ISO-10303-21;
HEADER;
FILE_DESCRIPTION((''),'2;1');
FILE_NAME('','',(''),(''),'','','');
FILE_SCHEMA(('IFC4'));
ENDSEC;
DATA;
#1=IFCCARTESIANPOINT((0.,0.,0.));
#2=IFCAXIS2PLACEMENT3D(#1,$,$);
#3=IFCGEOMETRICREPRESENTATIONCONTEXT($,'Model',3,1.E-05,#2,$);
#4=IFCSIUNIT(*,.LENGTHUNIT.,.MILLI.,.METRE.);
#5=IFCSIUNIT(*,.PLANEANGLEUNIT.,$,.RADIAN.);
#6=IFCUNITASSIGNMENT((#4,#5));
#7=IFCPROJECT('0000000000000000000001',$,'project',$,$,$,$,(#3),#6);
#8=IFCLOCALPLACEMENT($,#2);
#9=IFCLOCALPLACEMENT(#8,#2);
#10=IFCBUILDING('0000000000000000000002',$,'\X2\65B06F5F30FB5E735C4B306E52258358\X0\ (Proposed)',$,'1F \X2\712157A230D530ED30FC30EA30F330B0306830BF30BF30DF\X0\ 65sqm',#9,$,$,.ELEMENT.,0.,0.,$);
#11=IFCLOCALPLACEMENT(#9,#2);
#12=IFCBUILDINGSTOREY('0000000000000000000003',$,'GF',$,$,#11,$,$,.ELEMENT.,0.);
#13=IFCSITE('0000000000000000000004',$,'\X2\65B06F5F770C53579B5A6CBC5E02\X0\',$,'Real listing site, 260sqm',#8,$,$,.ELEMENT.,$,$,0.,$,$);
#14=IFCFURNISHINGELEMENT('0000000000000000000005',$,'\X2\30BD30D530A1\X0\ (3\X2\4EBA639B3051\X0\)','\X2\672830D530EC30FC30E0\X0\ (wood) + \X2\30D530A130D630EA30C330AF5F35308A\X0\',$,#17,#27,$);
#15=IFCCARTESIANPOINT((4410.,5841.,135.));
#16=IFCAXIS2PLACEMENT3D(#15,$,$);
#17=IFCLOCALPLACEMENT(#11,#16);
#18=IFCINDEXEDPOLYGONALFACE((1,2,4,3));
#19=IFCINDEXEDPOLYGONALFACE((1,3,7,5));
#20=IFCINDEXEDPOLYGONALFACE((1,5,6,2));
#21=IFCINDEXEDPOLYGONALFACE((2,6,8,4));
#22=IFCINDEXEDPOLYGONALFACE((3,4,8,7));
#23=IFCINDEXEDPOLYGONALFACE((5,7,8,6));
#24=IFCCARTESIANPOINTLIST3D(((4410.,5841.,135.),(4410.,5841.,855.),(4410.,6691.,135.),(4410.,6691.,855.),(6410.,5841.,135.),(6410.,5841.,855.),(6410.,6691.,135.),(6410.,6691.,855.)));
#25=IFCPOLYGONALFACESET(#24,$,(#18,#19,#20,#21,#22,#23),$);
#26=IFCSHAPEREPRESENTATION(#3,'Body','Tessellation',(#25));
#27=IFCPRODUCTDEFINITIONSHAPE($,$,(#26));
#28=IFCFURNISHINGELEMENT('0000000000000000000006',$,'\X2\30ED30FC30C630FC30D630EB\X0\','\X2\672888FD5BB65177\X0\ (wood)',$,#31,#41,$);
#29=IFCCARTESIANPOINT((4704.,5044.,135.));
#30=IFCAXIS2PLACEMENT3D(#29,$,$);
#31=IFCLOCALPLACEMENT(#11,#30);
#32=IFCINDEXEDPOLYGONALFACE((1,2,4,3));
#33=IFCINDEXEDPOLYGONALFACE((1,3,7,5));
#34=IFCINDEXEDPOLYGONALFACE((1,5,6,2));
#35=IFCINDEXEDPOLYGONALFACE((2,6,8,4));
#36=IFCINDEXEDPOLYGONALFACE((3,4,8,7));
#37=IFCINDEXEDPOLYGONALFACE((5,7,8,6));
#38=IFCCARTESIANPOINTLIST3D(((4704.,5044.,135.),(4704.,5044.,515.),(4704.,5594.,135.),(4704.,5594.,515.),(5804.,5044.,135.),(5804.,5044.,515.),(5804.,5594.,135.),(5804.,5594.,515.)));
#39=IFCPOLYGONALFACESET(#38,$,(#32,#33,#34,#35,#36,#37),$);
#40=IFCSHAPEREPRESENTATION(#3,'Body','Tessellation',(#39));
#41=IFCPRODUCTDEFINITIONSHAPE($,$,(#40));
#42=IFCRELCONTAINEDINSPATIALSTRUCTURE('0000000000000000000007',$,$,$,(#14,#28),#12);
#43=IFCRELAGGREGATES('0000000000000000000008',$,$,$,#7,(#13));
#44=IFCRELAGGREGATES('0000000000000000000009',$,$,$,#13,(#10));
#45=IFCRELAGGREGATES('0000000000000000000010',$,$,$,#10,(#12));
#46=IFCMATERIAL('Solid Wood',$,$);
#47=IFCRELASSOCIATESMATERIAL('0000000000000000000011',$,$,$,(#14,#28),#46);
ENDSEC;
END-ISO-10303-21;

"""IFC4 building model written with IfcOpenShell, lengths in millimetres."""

from ifc_helpers import new_model, si_unit, frame, frame_2d, origin, place, context, project, spatial, rectangle, extrude, material, element, save


model = new_model("IFC4")

# Units and contexts
model_context = context("Model", 3, precision=1e-05, world=origin())
ifc_project = project(units=[si_unit("LENGTHUNIT", "METRE", prefix="MILLI"), si_unit("PLANEANGLEUNIT", "RADIAN")], contexts=[model_context])

# Site, building, storey
site_placement = place(None, origin())
site = spatial("IfcSite", under=ifc_project, at=site_placement, Name="新潟県南魚沼市", ObjectType="Real listing site, 260sqm", CompositionType="ELEMENT", RefElevation=0.0)
building_placement = place(site_placement, origin())
building = spatial("IfcBuilding", under=site, at=building_placement, Name="新潟・平屋の別荘 (Proposed)", ObjectType="1F 無垢フローリングとタタミ 65sqm", CompositionType="ELEMENT", ElevationOfRefHeight=0.0, ElevationOfTerrain=0.0)
storey_placement = place(building_placement, origin())
storey = spatial("IfcBuildingStorey", under=building, at=storey_placement, Name="GF", CompositionType="ELEMENT", Elevation=0.0)

# Shared definitions
ifc_material_1 = material(Name="Solid Wood")

# Furnishing elements
furnishing_1_placement = place(storey_placement, frame((4410.0, 5841.0, 135.0)))
element("IfcFurnishingElement", 1, at=furnishing_1_placement, inside=storey, material=ifc_material_1, Name="ソファ (3人掛け)", Description="木フレーム (wood) + ファブリック張り", context=model_context, shape_type="SweptSolid", body=[
    extrude(rectangle(XDim=2000.0, YDim=850.0, at=frame_2d((1000.0, 425.0))), frame((4410.0, 5841.0, 135.0)), (0.0, 0.0, 1.0), 720.0),
])
furnishing_2_placement = place(storey_placement, frame((4704.0, 5044.0, 135.0)))
element("IfcFurnishingElement", 2, at=furnishing_2_placement, inside=storey, material=ifc_material_1, Name="ローテーブル", Description="木製家具 (wood)", context=model_context, shape_type="SweptSolid", body=[
    extrude(rectangle(XDim=1100.0, YDim=550.0, at=frame_2d((550.0, 275.0))), frame((4704.0, 5044.0, 135.0)), (0.0, 0.0, 1.0), 380.0),
])

save(model, "model.ifc")
